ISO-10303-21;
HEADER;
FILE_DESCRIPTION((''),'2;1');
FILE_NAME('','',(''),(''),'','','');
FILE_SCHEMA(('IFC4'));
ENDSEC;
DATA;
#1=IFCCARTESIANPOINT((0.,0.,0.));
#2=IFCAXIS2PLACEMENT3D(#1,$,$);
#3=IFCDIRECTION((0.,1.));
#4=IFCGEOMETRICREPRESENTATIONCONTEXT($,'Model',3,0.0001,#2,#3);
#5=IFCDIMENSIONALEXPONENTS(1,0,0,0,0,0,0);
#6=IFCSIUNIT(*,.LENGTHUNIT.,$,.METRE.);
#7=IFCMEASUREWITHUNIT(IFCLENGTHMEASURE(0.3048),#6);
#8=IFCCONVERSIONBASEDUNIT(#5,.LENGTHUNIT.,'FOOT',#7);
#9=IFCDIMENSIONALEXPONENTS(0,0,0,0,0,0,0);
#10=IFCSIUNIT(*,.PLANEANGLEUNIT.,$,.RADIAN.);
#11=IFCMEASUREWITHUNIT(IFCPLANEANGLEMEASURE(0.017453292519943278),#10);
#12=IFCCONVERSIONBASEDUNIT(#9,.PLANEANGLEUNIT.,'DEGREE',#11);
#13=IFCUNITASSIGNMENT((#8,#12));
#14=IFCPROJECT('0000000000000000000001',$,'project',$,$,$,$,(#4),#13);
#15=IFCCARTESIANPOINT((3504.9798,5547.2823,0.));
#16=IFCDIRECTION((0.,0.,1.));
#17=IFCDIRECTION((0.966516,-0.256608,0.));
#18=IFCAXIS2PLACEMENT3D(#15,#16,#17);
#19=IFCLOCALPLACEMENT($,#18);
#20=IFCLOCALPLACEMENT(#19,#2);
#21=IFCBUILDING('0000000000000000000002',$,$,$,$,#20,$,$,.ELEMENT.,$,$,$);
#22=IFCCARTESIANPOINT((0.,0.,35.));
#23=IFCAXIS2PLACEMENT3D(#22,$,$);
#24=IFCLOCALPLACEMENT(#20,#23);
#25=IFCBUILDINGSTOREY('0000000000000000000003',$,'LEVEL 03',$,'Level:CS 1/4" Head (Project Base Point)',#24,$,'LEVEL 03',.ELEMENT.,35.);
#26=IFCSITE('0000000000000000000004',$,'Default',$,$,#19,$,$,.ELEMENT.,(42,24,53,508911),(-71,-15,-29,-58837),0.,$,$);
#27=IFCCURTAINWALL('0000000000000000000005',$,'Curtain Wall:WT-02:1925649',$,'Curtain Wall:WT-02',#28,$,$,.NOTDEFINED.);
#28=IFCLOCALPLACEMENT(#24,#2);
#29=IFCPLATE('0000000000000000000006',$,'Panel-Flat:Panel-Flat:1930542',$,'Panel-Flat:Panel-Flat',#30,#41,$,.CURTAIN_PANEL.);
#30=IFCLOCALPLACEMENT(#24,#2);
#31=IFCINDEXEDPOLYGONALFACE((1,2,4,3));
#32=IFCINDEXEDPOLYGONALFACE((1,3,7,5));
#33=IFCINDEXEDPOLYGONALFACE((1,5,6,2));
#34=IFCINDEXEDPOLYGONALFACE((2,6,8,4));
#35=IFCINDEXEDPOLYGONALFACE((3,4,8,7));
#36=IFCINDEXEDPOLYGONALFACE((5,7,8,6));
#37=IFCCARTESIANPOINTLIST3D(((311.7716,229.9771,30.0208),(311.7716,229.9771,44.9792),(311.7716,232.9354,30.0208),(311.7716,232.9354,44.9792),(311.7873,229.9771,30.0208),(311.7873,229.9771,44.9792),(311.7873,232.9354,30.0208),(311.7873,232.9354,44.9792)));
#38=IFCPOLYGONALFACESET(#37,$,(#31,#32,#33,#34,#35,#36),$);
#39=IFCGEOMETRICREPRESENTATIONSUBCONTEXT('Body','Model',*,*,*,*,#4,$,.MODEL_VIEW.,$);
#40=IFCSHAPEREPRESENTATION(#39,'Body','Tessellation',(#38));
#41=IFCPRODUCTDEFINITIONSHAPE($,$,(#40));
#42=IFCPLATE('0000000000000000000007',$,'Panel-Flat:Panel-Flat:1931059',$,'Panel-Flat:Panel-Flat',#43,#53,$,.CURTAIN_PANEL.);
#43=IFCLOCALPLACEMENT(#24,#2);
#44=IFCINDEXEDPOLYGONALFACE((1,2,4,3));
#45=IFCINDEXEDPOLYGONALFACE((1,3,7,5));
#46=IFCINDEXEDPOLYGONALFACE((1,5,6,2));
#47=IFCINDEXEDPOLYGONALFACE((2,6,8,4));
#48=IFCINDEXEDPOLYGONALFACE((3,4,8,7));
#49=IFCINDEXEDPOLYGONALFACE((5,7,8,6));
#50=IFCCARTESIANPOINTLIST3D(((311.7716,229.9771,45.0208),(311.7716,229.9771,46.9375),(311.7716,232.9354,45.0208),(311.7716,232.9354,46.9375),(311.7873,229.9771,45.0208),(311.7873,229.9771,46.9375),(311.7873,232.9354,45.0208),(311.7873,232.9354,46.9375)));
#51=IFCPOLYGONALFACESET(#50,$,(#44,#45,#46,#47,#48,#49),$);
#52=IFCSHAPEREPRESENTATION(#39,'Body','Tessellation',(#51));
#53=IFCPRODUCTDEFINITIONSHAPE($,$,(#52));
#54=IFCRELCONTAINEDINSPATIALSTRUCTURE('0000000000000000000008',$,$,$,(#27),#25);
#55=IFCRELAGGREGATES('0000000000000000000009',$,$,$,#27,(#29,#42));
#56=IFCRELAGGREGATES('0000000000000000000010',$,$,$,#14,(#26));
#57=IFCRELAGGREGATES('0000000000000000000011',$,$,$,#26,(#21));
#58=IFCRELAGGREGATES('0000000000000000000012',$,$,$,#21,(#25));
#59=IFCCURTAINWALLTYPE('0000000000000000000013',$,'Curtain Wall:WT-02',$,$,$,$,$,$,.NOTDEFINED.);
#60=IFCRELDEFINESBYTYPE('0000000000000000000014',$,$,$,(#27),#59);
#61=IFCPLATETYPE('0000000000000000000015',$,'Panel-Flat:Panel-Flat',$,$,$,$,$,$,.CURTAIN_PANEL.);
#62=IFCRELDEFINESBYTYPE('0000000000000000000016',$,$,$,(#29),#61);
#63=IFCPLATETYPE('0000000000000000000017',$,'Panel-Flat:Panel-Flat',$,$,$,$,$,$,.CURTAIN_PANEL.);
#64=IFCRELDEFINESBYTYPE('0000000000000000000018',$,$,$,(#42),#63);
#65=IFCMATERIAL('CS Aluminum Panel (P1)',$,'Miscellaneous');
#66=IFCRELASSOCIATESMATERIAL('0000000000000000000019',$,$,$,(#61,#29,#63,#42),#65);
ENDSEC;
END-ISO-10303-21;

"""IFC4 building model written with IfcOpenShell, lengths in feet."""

from ifc_helpers import new_model, entity, si_unit, converted_unit, direction, frame, origin, place, context, subcontext, project, spatial, indexed_curve, outline, extrude, source, transform, mapped, material, type_object, type_shapes, element, aggregate, save


model = new_model("IFC4")

# Units and contexts
model_context = context("Model", 3, precision=0.0001, world=origin(), true_north=direction((0.0, 1.0)))
body_context = subcontext(model_context, "Body", "Model", "MODEL_VIEW")
ifc_project = project(units=[converted_unit("LENGTHUNIT", "FOOT", entity("IfcLengthMeasure", 0.3048), si_unit("LENGTHUNIT", "METRE"), dimensions=[1, 0, 0, 0, 0, 0, 0]), converted_unit("PLANEANGLEUNIT", "DEGREE", entity("IfcPlaneAngleMeasure", 0.017453292519943278), si_unit("PLANEANGLEUNIT", "RADIAN"), dimensions=[0, 0, 0, 0, 0, 0, 0])], contexts=[model_context])

# Site, building, storey
site_placement = place(None, frame((3504.9798, 5547.2823, 0.0), z_axis=(0.0, 0.0, 1.0), x_axis=(0.966516, -0.256608, 0.0)))
site = spatial("IfcSite", under=ifc_project, at=site_placement, Name="Default", CompositionType="ELEMENT", RefLatitude=(42, 24, 53, 508911), RefLongitude=(-71, -15, -29, -58837), RefElevation=0.0)
building_placement = place(site_placement, origin())
building = spatial("IfcBuilding", under=site, at=building_placement, CompositionType="ELEMENT")
storey_placement = place(building_placement, frame((0.0, 0.0, 35.0)))
storey = spatial("IfcBuildingStorey", under=building, at=storey_placement, Name="LEVEL 03", ObjectType="Level:CS 1/4\" Head (Project Base Point)", LongName="LEVEL 03", CompositionType="ELEMENT", Elevation=35.0)

# Curtain wall
curtain_wall_type = type_object("IfcCurtainWallType", Name="Curtain Wall:WT-02", PredefinedType="NOTDEFINED")
ifc_material_1 = material(Name="CS Aluminum Panel (P1)", Category="Miscellaneous")
curtain_wall_1_placement = place(storey_placement, frame((0.0, 0.0, -35.0)))
curtain_wall_1 = element("IfcCurtainWall", 1, at=curtain_wall_1_placement, inside=storey, type_object=curtain_wall_type, Name="Curtain Wall:WT-02:1925649", ObjectType="Curtain Wall:WT-02", PredefinedType="NOTDEFINED")

# Plates
plate_type_1 = type_object("IfcPlateType", Name="Panel-Flat:Panel-Flat", PredefinedType="CURTAIN_PANEL", material=ifc_material_1)
shared_shape_1 = source(origin(), body_context, "Body", "SweptSolid", [
    extrude(outline(indexed_curve([(-0.0078, -1.4792), (0.0078, -1.4792), (0.0078, 1.4792), (-0.0078, 1.4792), (-0.0078, -1.4792)], self_intersect=False)), frame((0.0, -0.0078, 0.0208), z_axis=(0.0, 0.0, 1.0), x_axis=(0.0, -1.0, 0.0)), (0.0, 0.0, 1.0), 14.9583),
])
type_shapes(plate_type_1, [shared_shape_1])
plate_1_placement = place(curtain_wall_1_placement, frame((311.7873, 231.4563, 65.0), z_axis=(0.0, 0.0, 1.0), x_axis=(0.0, -1.0, 0.0)))
plate_1 = element("IfcPlate", 2, at=plate_1_placement, type_object=plate_type_1, material=ifc_material_1, Name="Panel-Flat:Panel-Flat:1930542", ObjectType="Panel-Flat:Panel-Flat", PredefinedType="CURTAIN_PANEL", context=body_context, shape_type="MappedRepresentation", body=[
    mapped(shared_shape_1, transform((0.0, 0.0, 0.0), scale=1.0)),
])
plate_type_2 = type_object("IfcPlateType", Name="Panel-Flat:Panel-Flat", PredefinedType="CURTAIN_PANEL", material=ifc_material_1)
shared_shape_2 = source(origin(), body_context, "Body", "SweptSolid", [
    extrude(outline(indexed_curve([(-0.0078, -1.4792), (0.0078, -1.4792), (0.0078, 1.4792), (-0.0078, 1.4792), (-0.0078, -1.4792)], self_intersect=False)), frame((0.0, -0.0078, 0.0208), z_axis=(0.0, 0.0, 1.0), x_axis=(0.0, -1.0, 0.0)), (0.0, 0.0, 1.0), 1.9167),
])
type_shapes(plate_type_2, [shared_shape_2])
plate_2_placement = place(curtain_wall_1_placement, frame((311.7873, 231.4563, 80.0), z_axis=(0.0, 0.0, 1.0), x_axis=(0.0, -1.0, 0.0)))
plate_2 = element("IfcPlate", 3, at=plate_2_placement, type_object=plate_type_2, material=ifc_material_1, Name="Panel-Flat:Panel-Flat:1931059", ObjectType="Panel-Flat:Panel-Flat", PredefinedType="CURTAIN_PANEL", context=body_context, shape_type="MappedRepresentation", body=[
    mapped(shared_shape_2, transform((0.0, 0.0, 0.0), scale=1.0)),
])
aggregate(curtain_wall_1, [plate_1, plate_2])

save(model, "model.ifc")
